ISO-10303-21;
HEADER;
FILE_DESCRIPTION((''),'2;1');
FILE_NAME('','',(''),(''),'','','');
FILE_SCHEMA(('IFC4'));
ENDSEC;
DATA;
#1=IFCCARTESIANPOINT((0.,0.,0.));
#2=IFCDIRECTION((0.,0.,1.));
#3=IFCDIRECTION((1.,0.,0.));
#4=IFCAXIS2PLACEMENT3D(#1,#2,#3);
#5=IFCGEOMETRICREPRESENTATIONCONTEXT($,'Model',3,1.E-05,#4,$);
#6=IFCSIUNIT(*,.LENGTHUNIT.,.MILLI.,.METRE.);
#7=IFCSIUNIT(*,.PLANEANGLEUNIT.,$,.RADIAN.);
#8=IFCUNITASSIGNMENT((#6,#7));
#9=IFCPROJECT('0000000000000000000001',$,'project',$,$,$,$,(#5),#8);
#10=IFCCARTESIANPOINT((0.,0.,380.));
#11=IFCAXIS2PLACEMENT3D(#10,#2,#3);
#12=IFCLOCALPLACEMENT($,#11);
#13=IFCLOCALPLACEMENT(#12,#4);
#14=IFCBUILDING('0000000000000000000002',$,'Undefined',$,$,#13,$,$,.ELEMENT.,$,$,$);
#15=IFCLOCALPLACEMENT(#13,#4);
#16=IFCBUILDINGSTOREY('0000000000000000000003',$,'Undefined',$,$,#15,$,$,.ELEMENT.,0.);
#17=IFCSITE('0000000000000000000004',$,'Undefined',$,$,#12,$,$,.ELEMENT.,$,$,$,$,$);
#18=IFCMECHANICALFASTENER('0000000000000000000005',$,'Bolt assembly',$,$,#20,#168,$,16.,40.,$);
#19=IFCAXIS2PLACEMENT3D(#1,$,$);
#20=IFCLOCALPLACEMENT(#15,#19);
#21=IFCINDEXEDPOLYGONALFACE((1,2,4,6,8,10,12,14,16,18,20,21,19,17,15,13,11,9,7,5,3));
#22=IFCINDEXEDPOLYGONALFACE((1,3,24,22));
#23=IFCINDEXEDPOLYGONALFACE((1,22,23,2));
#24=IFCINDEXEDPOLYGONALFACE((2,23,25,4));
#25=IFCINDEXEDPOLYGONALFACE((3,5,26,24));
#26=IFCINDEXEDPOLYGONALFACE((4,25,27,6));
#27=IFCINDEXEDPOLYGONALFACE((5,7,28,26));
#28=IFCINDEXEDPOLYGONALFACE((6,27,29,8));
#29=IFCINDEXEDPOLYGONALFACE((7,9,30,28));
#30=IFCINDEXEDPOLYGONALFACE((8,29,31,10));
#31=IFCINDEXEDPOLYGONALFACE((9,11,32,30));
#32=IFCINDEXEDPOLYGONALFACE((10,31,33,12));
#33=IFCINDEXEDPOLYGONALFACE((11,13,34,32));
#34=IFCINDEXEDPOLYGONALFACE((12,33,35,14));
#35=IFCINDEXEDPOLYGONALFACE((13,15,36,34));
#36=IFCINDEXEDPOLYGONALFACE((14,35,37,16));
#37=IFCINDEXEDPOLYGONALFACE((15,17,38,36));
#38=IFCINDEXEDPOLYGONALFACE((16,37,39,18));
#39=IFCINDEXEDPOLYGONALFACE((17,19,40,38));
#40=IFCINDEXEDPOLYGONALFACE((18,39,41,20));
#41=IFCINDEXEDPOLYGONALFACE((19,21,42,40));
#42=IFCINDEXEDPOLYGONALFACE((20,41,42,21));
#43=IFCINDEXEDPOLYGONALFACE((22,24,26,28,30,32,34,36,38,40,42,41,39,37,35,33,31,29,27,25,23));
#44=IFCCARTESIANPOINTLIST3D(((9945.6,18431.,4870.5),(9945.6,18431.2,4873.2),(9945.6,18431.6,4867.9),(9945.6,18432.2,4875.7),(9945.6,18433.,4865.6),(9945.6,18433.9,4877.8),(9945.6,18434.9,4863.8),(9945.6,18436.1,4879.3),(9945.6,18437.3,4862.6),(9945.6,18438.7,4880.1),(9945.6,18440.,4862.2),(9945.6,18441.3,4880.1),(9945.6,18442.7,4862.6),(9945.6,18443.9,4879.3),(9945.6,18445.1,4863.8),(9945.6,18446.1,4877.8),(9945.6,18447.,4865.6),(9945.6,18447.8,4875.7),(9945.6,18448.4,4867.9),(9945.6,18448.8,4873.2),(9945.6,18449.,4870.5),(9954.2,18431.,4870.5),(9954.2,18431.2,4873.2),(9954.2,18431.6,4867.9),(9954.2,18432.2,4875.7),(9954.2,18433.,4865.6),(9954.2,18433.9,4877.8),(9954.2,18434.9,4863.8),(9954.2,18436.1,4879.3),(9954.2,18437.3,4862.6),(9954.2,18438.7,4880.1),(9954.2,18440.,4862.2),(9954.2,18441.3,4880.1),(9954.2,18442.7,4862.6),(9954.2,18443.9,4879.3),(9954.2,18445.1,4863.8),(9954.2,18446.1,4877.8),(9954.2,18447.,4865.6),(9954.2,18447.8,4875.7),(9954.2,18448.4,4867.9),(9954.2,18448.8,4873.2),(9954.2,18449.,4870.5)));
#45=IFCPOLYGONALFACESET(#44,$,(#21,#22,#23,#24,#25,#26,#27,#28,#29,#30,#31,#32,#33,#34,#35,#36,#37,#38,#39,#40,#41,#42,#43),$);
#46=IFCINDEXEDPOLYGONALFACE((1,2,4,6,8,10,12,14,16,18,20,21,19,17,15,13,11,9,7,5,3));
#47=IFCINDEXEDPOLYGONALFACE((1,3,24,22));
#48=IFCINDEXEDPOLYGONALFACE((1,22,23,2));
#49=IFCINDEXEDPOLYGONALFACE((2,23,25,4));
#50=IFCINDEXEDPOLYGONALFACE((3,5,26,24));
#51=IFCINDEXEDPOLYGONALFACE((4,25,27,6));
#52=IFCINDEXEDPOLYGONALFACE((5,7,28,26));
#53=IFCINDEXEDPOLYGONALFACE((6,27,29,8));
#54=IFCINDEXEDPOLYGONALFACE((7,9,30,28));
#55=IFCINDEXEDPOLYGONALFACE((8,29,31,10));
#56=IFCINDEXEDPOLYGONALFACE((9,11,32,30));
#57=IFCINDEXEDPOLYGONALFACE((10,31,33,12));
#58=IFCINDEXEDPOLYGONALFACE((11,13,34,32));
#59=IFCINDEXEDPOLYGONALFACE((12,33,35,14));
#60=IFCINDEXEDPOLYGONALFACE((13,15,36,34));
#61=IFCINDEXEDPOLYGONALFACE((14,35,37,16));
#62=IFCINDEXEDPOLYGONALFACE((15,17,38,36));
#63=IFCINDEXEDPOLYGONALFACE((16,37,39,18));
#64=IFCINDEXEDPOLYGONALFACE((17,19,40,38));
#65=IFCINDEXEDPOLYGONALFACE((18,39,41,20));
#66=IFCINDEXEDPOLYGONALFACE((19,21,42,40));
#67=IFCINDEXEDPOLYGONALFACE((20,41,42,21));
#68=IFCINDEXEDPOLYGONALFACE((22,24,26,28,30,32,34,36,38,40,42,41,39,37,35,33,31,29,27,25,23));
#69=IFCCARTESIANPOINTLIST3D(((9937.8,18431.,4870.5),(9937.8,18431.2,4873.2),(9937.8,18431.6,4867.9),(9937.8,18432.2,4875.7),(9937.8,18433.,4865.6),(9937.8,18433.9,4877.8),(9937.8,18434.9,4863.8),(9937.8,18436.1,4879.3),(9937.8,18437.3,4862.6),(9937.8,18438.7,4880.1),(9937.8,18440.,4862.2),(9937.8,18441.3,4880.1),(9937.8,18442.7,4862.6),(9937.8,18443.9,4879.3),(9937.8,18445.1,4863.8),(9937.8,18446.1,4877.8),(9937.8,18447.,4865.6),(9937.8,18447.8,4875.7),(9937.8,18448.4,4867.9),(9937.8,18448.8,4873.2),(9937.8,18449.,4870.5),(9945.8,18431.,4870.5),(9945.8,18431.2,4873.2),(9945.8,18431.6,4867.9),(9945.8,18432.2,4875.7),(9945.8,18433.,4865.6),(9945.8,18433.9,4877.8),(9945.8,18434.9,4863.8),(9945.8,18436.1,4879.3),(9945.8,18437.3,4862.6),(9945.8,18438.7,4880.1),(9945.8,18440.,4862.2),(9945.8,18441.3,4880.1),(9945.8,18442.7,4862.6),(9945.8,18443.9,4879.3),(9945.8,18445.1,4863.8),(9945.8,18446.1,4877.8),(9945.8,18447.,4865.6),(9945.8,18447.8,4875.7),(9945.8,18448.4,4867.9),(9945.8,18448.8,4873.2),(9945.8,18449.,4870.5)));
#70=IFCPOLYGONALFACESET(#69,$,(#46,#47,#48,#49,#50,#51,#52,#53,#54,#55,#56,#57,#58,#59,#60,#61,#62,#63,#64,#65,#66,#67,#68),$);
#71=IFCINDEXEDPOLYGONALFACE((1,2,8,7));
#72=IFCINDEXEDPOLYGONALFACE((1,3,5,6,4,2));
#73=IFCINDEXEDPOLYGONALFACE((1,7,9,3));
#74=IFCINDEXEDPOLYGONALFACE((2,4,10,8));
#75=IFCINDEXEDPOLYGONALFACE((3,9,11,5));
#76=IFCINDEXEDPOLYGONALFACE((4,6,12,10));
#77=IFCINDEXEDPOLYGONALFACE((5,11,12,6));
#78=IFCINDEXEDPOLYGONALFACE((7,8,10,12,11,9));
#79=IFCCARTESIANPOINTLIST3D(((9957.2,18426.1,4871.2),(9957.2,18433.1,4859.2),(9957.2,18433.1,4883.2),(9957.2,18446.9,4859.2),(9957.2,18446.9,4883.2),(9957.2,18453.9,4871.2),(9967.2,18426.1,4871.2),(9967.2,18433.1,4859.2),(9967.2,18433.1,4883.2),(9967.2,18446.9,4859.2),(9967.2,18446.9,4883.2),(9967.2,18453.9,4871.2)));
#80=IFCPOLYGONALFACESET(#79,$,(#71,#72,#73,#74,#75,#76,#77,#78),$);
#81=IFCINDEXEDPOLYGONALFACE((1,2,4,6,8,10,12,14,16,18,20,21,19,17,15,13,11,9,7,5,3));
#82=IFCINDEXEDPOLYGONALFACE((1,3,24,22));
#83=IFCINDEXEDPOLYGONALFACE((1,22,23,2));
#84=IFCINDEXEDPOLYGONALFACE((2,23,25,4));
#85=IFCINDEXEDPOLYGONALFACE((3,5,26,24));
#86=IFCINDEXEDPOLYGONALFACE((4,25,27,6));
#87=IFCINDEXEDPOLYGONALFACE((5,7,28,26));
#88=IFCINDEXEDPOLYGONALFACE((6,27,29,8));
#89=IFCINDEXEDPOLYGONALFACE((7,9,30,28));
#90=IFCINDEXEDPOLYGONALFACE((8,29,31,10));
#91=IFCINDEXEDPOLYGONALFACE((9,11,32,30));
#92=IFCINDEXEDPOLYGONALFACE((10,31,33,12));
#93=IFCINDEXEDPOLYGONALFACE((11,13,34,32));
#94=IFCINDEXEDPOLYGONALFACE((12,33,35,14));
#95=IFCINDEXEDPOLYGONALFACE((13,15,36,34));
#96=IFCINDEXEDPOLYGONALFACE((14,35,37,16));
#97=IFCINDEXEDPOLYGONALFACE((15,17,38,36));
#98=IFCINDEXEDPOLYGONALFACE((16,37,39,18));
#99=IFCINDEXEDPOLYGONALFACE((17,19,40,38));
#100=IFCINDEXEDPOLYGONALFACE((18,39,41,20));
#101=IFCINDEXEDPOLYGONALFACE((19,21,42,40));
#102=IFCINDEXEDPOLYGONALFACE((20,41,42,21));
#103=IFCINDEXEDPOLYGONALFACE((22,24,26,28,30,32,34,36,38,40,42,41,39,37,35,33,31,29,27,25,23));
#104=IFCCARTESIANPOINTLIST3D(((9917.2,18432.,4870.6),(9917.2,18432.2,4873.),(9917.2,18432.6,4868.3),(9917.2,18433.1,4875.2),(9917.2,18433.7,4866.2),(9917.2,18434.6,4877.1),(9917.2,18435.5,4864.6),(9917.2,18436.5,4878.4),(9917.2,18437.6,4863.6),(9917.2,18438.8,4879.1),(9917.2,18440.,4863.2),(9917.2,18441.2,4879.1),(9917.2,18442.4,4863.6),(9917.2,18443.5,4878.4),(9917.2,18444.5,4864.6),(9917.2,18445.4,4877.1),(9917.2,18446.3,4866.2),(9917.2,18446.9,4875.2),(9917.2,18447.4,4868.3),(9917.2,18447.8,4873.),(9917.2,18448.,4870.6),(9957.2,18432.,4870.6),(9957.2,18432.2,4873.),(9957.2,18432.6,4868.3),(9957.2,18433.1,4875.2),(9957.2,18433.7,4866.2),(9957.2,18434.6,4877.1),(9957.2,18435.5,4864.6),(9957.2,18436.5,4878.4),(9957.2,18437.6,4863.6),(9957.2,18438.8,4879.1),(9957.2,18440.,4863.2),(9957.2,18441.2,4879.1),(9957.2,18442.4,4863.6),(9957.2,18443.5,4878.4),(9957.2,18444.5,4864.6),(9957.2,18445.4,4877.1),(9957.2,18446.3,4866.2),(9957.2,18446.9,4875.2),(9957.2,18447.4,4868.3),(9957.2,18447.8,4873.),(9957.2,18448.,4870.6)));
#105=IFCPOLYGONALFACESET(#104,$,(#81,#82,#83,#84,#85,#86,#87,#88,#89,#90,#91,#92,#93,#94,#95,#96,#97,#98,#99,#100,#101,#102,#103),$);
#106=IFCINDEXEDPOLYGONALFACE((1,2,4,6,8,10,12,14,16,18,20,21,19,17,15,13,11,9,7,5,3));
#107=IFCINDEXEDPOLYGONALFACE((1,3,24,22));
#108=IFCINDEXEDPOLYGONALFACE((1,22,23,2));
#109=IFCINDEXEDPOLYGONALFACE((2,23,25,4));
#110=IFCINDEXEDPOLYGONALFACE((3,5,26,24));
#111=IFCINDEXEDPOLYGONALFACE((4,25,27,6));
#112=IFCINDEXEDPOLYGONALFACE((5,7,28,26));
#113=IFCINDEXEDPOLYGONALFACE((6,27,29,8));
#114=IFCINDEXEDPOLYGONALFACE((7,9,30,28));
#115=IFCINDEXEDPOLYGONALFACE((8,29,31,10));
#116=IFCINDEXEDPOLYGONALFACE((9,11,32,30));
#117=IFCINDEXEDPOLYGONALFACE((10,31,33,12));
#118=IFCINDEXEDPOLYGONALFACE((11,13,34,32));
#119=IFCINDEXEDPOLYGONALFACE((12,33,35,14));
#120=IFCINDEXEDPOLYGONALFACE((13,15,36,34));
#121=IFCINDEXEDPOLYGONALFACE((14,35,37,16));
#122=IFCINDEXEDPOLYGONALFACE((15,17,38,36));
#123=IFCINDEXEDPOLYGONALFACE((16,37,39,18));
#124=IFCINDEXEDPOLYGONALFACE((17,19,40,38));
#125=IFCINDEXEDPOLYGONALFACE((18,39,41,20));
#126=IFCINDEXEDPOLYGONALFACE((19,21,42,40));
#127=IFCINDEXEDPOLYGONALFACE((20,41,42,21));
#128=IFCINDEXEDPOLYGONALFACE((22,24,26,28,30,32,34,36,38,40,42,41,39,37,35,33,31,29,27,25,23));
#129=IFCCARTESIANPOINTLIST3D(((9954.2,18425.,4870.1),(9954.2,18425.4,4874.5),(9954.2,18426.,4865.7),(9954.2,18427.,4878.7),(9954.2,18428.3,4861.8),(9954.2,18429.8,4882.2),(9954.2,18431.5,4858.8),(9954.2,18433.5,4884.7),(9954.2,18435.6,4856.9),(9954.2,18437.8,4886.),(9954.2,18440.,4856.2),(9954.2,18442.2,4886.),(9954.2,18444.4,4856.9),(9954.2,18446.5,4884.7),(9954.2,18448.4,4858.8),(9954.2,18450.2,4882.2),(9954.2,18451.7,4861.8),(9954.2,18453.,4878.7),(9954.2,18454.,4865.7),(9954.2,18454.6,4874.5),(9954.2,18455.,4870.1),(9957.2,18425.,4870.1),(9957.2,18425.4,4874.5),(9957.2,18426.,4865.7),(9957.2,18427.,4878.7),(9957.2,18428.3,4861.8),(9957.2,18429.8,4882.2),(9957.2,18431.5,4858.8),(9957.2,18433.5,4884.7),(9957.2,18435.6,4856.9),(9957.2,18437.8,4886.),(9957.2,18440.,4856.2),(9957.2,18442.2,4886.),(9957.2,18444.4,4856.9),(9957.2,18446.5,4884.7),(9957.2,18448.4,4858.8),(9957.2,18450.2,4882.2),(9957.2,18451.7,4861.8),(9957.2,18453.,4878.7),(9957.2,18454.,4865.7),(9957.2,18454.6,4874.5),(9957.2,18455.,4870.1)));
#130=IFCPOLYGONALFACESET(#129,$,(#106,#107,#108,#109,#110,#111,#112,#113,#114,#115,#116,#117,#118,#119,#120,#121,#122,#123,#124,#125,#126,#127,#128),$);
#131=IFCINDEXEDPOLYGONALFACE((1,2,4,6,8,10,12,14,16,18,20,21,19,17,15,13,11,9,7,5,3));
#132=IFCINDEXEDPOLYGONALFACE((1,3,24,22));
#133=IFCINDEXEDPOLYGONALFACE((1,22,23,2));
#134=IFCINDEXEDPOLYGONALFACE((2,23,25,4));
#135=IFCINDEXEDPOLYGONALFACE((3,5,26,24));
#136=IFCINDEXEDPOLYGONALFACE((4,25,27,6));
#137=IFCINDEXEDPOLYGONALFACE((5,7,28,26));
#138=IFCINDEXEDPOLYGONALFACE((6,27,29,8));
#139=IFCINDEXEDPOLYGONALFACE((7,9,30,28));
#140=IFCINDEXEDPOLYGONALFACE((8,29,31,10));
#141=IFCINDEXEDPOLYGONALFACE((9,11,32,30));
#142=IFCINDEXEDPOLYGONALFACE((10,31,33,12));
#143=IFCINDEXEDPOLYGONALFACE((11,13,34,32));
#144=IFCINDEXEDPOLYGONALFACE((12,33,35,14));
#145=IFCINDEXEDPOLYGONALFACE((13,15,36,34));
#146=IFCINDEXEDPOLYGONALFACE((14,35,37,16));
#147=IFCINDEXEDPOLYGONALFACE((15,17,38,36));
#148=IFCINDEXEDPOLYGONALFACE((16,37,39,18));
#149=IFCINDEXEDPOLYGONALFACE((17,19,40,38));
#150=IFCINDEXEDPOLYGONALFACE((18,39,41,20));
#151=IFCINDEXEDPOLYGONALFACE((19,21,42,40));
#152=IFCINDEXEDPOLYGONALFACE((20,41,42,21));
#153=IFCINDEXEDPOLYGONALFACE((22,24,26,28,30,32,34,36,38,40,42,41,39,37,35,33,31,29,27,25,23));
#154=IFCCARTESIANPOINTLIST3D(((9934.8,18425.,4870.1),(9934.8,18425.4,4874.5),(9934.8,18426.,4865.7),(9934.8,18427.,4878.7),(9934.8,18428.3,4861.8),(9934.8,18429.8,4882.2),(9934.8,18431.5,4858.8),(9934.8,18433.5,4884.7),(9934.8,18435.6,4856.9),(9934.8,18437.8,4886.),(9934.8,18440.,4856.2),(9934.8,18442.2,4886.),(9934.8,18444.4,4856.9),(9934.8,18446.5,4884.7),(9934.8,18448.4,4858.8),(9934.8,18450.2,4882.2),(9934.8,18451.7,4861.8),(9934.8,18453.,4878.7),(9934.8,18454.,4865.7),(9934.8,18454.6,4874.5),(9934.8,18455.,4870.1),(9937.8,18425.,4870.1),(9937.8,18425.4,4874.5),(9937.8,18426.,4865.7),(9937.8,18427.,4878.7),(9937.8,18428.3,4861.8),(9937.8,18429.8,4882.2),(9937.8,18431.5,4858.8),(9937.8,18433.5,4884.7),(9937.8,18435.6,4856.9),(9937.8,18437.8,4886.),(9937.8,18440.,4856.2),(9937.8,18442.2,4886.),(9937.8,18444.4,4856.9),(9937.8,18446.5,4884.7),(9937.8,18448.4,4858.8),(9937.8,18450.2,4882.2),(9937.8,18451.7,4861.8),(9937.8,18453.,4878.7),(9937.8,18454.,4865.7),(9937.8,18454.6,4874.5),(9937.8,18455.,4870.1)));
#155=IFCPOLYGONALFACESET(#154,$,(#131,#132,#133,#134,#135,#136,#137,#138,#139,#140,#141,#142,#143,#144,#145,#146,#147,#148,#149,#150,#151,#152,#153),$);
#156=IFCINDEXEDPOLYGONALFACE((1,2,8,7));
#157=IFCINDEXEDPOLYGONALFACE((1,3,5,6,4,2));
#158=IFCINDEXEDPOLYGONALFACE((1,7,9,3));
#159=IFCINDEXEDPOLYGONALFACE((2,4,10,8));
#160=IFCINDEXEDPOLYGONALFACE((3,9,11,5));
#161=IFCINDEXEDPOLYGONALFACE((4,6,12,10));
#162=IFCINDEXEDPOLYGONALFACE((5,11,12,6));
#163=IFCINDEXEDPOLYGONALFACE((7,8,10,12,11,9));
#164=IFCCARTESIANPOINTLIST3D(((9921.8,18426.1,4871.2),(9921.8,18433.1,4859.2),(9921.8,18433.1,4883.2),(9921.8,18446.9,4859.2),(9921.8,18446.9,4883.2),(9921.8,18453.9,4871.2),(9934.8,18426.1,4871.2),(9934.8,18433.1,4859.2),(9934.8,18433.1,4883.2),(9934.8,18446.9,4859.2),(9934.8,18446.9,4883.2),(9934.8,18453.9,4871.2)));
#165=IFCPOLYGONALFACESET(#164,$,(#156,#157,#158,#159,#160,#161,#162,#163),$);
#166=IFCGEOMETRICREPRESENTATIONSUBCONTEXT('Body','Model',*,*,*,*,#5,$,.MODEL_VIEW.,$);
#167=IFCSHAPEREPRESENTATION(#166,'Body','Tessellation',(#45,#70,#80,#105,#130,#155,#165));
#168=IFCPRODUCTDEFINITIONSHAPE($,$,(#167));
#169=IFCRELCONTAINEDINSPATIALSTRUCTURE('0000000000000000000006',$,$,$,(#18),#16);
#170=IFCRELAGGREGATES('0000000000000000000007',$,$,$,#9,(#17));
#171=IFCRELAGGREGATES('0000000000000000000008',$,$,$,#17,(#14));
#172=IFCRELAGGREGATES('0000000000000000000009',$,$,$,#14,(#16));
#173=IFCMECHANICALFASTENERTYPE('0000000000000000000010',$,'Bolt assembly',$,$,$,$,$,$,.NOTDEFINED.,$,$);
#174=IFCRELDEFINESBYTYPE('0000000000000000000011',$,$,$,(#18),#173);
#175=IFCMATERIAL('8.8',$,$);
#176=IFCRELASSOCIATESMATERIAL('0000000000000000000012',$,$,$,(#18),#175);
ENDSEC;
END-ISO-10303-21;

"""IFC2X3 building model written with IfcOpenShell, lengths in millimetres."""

from ifc_helpers import new_model, si_unit, frame, origin_with_axes, origin_2d_with_axis, place, context, subcontext, project, spatial, polyline, circle, outline, extrude, source, transform, mapped, material, type_object, element, save


model = new_model("IFC2X3")

# Units and contexts
model_context = context("Model", 3, precision=1e-05, world=origin_with_axes())
body_context = subcontext(model_context, "Body", "Model", "MODEL_VIEW")
ifc_project = project(units=[si_unit("LENGTHUNIT", "METRE", prefix="MILLI"), si_unit("PLANEANGLEUNIT", "RADIAN")], contexts=[model_context])

# Site, building, storey
site_placement = place(None, frame((0.0, 0.0, 380.0), z_axis=(0.0, 0.0, 1.0), x_axis=(1.0, 0.0, 0.0)))
site = spatial("IfcSite", under=ifc_project, at=site_placement, Name="Undefined", CompositionType="ELEMENT")
building_placement = place(site_placement, origin_with_axes())
building = spatial("IfcBuilding", under=site, at=building_placement, Name="Undefined", CompositionType="ELEMENT")
storey_placement = place(building_placement, origin_with_axes())
storey = spatial("IfcBuildingStorey", under=building, at=storey_placement, Name="Undefined", CompositionType="ELEMENT", Elevation=0.0)

# Mechanical fastener
ifc_material_1 = material(Name="8.8")
mechanical_fastener_type = type_object("IfcMechanicalFastenerType", Name="Bolt assembly")
shared_shape_1 = source(origin_with_axes(), body_context, "Body", "SweptSolid", [
    extrude(circle(Radius=9.0, at=origin_2d_with_axis()), frame((0.0, -8.4, 0.0), z_axis=(0.0, 1.0, 0.0), x_axis=(1.0, 0.0, 0.0)), (0.0, 0.0, 1.0), 8.5),
    extrude(circle(Radius=9.0, at=origin_2d_with_axis()), frame((0.0, -0.1, 0.0), z_axis=(0.0, 1.0, 0.0), x_axis=(1.0, 0.0, 0.0)), (0.0, 0.0, 1.0), 8.1),
    extrude(outline(polyline([(12.0, -6.9), (12.0, 6.9), (0.0, 13.9), (-12.0, 6.9), (-12.0, -6.9), (0.0, -13.9), (12.0, -6.9)])), frame((0.0, -21.5, 0.0), z_axis=(0.0, 1.0, 0.0), x_axis=(1.0, 0.0, 0.0)), (0.0, 0.0, 1.0), 10.0),
    extrude(circle(Radius=8.0, at=origin_2d_with_axis()), frame((0.0, -11.5, 0.0), z_axis=(0.0, 1.0, 0.0), x_axis=(1.0, 0.0, 0.0)), (0.0, 0.0, 1.0), 40.0),
    extrude(circle(Radius=15.0, at=origin_2d_with_axis()), frame((0.0, -11.5, 0.0), z_axis=(0.0, 1.0, 0.0), x_axis=(1.0, 0.0, 0.0)), (0.0, 0.0, 1.0), 3.0),
    extrude(circle(Radius=15.0, at=origin_2d_with_axis()), frame((0.0, 8.0, 0.0), z_axis=(0.0, 1.0, 0.0), x_axis=(1.0, 0.0, 0.0)), (0.0, 0.0, 1.0), 3.0),
    extrude(outline(polyline([(12.0, -6.9), (12.0, 6.9), (0.0, 13.9), (-12.0, 6.9), (-12.0, -6.9), (0.0, -13.9), (12.0, -6.9)])), frame((0.0, 11.0, 0.0), z_axis=(0.0, 1.0, 0.0), x_axis=(1.0, 0.0, 0.0)), (0.0, 0.0, 1.0), 13.0),
])
for number, where, z_axis, x_axis, name in (
    (1, (9945.8, 18402.5, 4951.2), (0.0, 1.0, 0.0), (0.0, 0.0, -1.0), "Bolt assembly"),
):
    element("IfcMechanicalFastener", number, at=place(storey_placement, frame(where, z_axis=z_axis, x_axis=x_axis)), inside=storey, type_object=mechanical_fastener_type, material=ifc_material_1, Name=name, NominalDiameter=16.0, NominalLength=40.0, context=body_context, shape_type="MappedRepresentation", body=[
        mapped(shared_shape_1, transform((80.0, 0.0, 37.5))),
    ])

save(model, "model.ifc")
